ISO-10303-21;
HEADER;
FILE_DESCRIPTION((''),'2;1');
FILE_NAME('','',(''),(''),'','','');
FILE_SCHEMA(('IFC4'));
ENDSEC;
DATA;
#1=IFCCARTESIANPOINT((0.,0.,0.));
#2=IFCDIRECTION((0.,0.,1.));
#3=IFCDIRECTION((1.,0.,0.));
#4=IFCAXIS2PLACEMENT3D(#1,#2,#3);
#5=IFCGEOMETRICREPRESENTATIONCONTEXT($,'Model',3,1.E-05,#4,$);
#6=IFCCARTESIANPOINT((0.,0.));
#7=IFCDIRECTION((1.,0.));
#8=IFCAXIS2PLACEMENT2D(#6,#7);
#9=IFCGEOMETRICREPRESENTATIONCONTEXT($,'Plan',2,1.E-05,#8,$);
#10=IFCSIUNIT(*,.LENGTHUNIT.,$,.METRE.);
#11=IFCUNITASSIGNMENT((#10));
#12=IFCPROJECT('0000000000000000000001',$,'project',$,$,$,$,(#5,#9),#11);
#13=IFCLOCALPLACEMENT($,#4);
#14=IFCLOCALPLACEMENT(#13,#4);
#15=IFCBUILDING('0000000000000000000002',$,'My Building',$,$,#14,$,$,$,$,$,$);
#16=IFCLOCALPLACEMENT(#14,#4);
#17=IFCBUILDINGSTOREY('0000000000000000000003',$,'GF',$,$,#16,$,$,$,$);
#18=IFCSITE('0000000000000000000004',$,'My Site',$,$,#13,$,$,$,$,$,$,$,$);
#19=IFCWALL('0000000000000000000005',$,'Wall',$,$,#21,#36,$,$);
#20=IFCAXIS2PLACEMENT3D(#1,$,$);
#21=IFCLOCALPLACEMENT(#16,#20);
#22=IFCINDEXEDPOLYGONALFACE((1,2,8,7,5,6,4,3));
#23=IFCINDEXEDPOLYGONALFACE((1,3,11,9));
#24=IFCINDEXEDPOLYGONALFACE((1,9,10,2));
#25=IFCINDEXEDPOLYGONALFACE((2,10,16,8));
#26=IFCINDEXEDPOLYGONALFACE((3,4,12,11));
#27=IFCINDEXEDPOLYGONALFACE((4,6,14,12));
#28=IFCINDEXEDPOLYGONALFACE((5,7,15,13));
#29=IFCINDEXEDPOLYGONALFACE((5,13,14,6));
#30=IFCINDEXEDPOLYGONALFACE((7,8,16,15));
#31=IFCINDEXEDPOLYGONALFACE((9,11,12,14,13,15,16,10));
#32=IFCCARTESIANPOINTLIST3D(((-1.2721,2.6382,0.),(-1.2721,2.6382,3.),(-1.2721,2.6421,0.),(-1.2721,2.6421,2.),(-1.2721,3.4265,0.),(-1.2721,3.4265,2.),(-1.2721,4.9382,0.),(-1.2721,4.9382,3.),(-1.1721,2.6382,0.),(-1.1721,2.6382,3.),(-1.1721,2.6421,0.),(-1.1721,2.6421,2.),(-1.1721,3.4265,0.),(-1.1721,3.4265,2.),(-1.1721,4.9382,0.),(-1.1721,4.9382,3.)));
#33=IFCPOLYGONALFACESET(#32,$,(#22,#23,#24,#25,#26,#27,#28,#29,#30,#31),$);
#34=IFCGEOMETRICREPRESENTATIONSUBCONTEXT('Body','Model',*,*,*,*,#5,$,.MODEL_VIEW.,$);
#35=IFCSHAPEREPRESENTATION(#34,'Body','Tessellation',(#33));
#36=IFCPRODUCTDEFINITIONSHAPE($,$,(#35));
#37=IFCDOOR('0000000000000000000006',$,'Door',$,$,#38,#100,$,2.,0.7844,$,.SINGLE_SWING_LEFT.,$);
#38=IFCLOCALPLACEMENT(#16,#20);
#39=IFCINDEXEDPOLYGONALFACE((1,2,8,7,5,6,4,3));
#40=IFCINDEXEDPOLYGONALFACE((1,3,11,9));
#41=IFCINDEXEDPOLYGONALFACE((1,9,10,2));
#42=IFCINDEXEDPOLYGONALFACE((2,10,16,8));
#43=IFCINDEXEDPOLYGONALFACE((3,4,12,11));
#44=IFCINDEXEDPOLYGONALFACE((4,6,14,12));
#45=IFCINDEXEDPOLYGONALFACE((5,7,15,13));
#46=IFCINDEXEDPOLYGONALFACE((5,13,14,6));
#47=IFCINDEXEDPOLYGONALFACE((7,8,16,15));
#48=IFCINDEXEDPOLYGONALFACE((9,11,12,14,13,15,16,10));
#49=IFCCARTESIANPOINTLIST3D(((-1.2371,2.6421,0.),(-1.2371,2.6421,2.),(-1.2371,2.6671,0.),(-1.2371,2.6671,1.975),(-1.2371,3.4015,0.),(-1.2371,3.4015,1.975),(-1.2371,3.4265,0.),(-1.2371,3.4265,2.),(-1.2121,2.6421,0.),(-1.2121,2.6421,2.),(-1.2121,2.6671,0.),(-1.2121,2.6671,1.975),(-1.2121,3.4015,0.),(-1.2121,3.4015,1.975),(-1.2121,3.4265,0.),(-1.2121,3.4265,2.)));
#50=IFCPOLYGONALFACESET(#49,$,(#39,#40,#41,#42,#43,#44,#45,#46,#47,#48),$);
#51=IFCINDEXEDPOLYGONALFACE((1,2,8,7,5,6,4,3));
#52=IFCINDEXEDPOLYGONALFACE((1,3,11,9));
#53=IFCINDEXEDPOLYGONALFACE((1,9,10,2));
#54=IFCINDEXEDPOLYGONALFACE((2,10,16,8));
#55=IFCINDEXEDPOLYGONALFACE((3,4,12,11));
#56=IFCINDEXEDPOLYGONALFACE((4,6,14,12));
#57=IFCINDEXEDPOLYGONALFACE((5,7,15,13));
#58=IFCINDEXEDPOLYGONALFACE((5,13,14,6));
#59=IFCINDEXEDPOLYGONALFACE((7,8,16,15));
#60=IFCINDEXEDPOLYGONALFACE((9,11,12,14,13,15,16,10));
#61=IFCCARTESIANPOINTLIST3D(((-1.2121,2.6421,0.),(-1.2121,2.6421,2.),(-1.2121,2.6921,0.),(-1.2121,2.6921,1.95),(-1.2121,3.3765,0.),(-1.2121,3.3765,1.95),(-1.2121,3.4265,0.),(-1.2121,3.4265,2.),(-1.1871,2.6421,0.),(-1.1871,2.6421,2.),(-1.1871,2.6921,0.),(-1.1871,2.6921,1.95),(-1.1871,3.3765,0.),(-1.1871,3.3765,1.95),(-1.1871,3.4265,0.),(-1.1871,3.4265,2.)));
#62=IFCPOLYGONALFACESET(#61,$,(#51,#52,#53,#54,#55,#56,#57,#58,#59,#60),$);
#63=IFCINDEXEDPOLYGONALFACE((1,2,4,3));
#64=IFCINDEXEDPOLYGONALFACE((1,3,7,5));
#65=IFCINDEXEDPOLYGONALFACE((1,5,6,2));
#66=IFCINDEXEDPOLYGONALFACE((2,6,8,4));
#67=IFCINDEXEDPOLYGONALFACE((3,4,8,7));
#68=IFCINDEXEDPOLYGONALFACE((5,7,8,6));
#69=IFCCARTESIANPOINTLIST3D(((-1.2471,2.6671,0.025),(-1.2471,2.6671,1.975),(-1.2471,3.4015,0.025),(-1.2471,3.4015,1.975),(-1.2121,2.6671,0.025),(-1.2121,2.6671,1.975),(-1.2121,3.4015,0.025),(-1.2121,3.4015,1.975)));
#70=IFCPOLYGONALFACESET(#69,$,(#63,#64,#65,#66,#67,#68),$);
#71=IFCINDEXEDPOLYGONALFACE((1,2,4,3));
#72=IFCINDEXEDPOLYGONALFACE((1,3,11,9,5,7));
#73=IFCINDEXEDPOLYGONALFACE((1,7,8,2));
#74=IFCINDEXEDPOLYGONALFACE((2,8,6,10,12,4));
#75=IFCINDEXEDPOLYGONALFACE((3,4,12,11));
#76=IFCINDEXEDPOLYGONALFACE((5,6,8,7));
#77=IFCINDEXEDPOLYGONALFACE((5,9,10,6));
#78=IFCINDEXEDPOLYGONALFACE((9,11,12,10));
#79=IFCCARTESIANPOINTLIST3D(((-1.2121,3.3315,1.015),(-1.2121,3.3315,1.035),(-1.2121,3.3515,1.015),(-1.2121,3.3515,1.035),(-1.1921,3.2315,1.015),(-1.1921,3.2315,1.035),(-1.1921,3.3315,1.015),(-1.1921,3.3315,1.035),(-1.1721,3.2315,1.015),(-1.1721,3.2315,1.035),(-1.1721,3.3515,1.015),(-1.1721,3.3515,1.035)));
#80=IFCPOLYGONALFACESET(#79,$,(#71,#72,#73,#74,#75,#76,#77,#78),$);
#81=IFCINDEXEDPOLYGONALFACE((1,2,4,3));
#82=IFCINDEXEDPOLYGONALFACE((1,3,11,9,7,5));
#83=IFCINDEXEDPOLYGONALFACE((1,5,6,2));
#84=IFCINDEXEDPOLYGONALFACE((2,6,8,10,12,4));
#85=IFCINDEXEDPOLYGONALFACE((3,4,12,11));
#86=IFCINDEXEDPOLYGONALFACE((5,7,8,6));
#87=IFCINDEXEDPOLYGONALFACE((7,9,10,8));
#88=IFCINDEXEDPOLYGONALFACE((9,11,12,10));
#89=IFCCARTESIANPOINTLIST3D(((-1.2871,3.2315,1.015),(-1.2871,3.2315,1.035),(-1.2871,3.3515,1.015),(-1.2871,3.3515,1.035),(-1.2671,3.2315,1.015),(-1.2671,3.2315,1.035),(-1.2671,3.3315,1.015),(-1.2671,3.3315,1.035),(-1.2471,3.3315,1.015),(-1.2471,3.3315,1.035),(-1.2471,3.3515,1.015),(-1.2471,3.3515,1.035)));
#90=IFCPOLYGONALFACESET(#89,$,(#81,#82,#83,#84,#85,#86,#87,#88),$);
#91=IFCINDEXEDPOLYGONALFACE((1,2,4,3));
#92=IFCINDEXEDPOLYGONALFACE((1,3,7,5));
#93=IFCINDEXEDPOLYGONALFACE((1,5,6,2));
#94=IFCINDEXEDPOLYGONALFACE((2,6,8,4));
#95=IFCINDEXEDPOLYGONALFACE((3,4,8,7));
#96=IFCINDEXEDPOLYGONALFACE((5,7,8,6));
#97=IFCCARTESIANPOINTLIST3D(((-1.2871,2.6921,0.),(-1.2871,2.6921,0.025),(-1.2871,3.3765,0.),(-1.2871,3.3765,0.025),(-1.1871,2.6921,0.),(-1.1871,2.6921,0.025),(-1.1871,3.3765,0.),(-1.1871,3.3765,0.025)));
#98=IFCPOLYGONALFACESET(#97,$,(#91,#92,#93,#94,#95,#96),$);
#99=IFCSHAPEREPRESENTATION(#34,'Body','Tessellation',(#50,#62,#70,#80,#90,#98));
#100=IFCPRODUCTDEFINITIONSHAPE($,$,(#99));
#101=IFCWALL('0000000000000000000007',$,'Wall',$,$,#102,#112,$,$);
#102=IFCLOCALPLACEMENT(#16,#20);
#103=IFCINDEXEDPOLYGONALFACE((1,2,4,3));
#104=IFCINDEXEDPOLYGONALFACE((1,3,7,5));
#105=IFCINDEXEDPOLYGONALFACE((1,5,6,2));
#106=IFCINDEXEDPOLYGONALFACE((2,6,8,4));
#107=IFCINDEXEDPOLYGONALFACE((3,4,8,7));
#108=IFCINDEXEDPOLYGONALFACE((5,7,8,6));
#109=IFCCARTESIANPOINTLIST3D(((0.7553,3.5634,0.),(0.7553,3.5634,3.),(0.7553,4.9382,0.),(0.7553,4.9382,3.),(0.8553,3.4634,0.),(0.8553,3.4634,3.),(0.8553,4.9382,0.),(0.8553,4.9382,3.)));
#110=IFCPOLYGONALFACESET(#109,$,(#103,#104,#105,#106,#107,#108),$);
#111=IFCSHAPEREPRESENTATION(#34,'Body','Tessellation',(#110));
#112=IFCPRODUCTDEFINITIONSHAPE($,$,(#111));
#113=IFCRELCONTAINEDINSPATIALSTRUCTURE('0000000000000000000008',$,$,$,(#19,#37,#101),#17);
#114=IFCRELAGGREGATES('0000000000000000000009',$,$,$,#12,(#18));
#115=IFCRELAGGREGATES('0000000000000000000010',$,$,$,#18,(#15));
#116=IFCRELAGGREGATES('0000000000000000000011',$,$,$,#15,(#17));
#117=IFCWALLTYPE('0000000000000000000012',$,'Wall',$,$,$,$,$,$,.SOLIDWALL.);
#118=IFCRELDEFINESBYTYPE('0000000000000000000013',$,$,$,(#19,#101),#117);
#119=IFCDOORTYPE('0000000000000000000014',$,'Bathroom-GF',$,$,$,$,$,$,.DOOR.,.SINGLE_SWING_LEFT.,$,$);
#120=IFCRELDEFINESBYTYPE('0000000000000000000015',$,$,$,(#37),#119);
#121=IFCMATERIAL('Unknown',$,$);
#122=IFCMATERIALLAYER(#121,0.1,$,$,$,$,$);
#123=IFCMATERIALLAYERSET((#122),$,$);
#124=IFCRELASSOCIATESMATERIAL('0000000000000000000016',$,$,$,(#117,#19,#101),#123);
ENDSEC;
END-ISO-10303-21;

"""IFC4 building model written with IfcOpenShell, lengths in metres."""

from ifc_helpers import new_model, entity, si_unit, frame, origin_with_axes, origin_2d_with_axis, place, context, subcontext, project, spatial, line, indexed_curve, outline, extrude, shape, source, transform, mapped, material, layer, layer_set, layer_usage, type_object, type_shapes, element, fill, save


model = new_model("IFC4")

# Units and contexts
model_context = context("Model", 3, precision=1e-05, world=origin_with_axes())
plan_context = context("Plan", 2, precision=1e-05, world=origin_2d_with_axis())
body_context_1 = subcontext(model_context, "Body", "Model", "MODEL_VIEW")
body_context_2 = subcontext(plan_context, "Body", "Plan", "PLAN_VIEW")
ifc_project = project(units=[si_unit("LENGTHUNIT", "METRE")], contexts=[model_context, plan_context])

# Site, building, storey
site_placement = place(None, origin_with_axes())
site = spatial("IfcSite", under=ifc_project, at=site_placement, Name="My Site")
building_placement = place(site_placement, origin_with_axes())
building = spatial("IfcBuilding", under=site, at=building_placement, Name="My Building")
storey_placement = place(building_placement, origin_with_axes())
storey = spatial("IfcBuildingStorey", under=building, at=storey_placement, Name="GF")

# Shared definitions
ifc_material = material(Name="Unknown")

# Shared definitions
ifc_layer_1 = layer(ifc_material, 0.1)
ifc_layer_set_1 = layer_set([ifc_layer_1])
wall_type = type_object("IfcWallType", Name="Wall", PredefinedType="SOLIDWALL", material=ifc_layer_set_1)

# Wall, opening, door
ifc_layer_usage_1 = layer_usage(ifc_layer_set_1, "AXIS2", "POSITIVE", 0.0)
wall_1_placement = place(storey_placement, frame((-1.1721, 2.6382, 0.0), z_axis=(0.0, 0.0, 1.0), x_axis=(0.0, 1.0, 0.0)))
wall_1 = element("IfcWall", 1, at=wall_1_placement, inside=storey, type_object=wall_type, material=ifc_layer_usage_1, Name="Wall", context=body_context_1, shape_type="SweptSolid", body=[
    extrude(outline(indexed_curve([(0.0, 0.0), (0.0, 0.1), (2.3, 0.1), (2.3, 0.0)], segments=[line(1, 2, 3, 4, 1)])), origin_with_axes(), (0.0, 0.0, 1.0), 3.0),
])
shared_shape_1 = source(origin_with_axes(), body_context_1, "Body", "SweptSolid", [
    extrude(outline(indexed_curve([(0.0, 0.0), (0.7844, 0.0), (0.7844, 2.0), (0.0, 2.0)], segments=[line(1, 2, 3, 4, 1)])), frame((0.0, -0.6, 0.0), z_axis=(0.0, -1.0, 0.0), x_axis=(1.0, 0.0, 0.0)), (0.0, 0.0, -1.0), 1.2),
])
opening_1_placement = place(wall_1_placement, frame((0.0039, 0.015, 0.0), z_axis=(0.0, 0.0, 1.0), x_axis=(1.0, 0.0, 0.0)))
opening_1 = element("IfcOpeningElement", 2, at=opening_1_placement, cuts=wall_1, PredefinedType="OPENING", context=body_context_1, shape_type="MappedRepresentation", body=[
    mapped(shared_shape_1, transform((0.0, 0.0, 0.0), x_axis=(1.0, 0.0, 0.0), y_axis=(0.0, 1.0, 0.0), z_axis=(0.0, 0.0, 1.0), scale=1.0)),
])
door_type_1 = type_object("IfcDoorType", Name="Bathroom-GF", OperationType="SINGLE_SWING_LEFT", PredefinedType="DOOR")
shared_shape_2 = source(origin_with_axes(), body_context_1, "Body", "SweptSolid", [
    extrude(outline(indexed_curve([(0.0, 0.0), (0.0, 2.0), (0.7844, 2.0), (0.7844, 0.0), (0.7594, 0.0), (0.7594, 1.975), (0.025, 1.975), (0.025, 0.0)], segments=[line(1, 2, 3, 4, 5, 6, 7, 8, 1)])), frame((0.0, 0.025, 0.0), z_axis=(0.0, -1.0, 0.0), x_axis=(1.0, 0.0, 0.0)), (0.0, 0.0, -1.0), 0.025),
    extrude(outline(indexed_curve([(0.0, 0.0), (0.0, 2.0), (0.7844, 2.0), (0.7844, 0.0), (0.7344, 0.0), (0.7344, 1.95), (0.05, 1.95), (0.05, 0.0)], segments=[line(1, 2, 3, 4, 5, 6, 7, 8, 1)])), frame((0.0, 0.0, 0.0), z_axis=(0.0, -1.0, 0.0), x_axis=(1.0, 0.0, 0.0)), (0.0, 0.0, -1.0), 0.025),
    extrude(outline(indexed_curve([(0.0, 0.0), (0.7344, 0.0), (0.7344, 0.035), (0.0, 0.035)], segments=[line(1, 2, 3, 4, 1)])), frame((0.025, 0.025, 0.025), z_axis=(0.0, 0.0, 1.0), x_axis=(1.0, 0.0, 0.0)), (0.0, 0.0, 1.0), 1.95),
    extrude(outline(indexed_curve([(0.0, 0.0), (0.0, -0.04), (-0.12, -0.04), (-0.12, -0.02), (-0.02, -0.02), (-0.02, 0.0)], segments=[line(1, 2, 3, 4, 5, 6, 1)])), frame((0.7094, 0.025, 1.015), z_axis=(0.0, 0.0, 1.0), x_axis=(1.0, 0.0, 0.0)), (0.0, 0.0, 1.0), 0.02),
    extrude(outline(indexed_curve([(0.0, 0.0), (0.0, 0.04), (-0.12, 0.04), (-0.12, 0.02), (-0.02, 0.02), (-0.02, 0.0)], segments=[line(1, 2, 3, 4, 5, 6, 1)])), frame((0.7094, 0.06, 1.015), z_axis=(0.0, 0.0, 1.0), x_axis=(1.0, 0.0, 0.0)), (0.0, 0.0, 1.0), 0.02),
    extrude(outline(indexed_curve([(0.0, 0.0), (0.6844, 0.0), (0.6844, 0.1), (0.0, 0.1)], segments=[line(1, 2, 3, 4, 1)])), frame((0.05, 0.0, 0.0), z_axis=(0.0, 0.0, 1.0), x_axis=(1.0, 0.0, 0.0)), (0.0, 0.0, 1.0), 0.025),
])
shared_shape_3 = source(origin_with_axes(), body_context_2, "Body", "Curve2D", [
    entity("IfcIndexedPolyCurve", entity("IfcCartesianPointList2D", [[0.0, 0.0], [0.0, 0.05], [0.025, 0.05], [0.025, 0.025], [0.05, 0.025], [0.05, 0.0]]), [entity("IfcLineIndex", [1, 2, 3, 4, 5, 6, 1])]),
    entity("IfcIndexedPolyCurve", entity("IfcCartesianPointList2D", [[0.7844, 0.0], [0.7844, 0.05], [0.7594, 0.05], [0.7594, 0.025], [0.7344, 0.025], [0.7344, 0.0]]), [entity("IfcLineIndex", [1, 2, 3, 4, 5, 6, 1])]),
    entity("IfcTrimmedCurve", entity("IfcEllipse", entity("IfcAxis2Placement2D", entity("IfcCartesianPoint", [0.06, 0.05]), entity("IfcDirection", [1.0, 0.0])), 0.6994, 0.7344), [entity("IfcCartesianPoint", [0.7594, 0.05])], [entity("IfcCartesianPoint", [0.06, 0.7844])], True, "CARTESIAN"),
    entity("IfcIndexedPolyCurve", entity("IfcCartesianPointList2D", [[0.025, 0.05], [0.06, 0.05], [0.06, 0.7844], [0.025, 0.7844]]), [entity("IfcLineIndex", [1, 2, 3, 4, 1])]),
])
type_shapes(door_type_1, [shared_shape_2, shared_shape_3])
door_1_placement = place(opening_1_placement, frame((0.0, 0.0, 0.0), z_axis=(0.0, 0.0, 1.0), x_axis=(1.0, 0.0, 0.0)))
door_1 = element("IfcDoor", 3, at=door_1_placement, inside=storey, type_object=door_type_1, Name="Door", OperationType="SINGLE_SWING_LEFT", OverallHeight=2.0, OverallWidth=0.7844, shapes=[
    shape(body_context_1, "Body", "MappedRepresentation", [mapped(shared_shape_2, transform((0.0, 0.0, 0.0), x_axis=(1.0, 0.0, 0.0), y_axis=(0.0, 1.0, 0.0), z_axis=(0.0, 0.0, 1.0), scale=1.0))]),
    shape(body_context_2, "Body", "MappedRepresentation", [mapped(shared_shape_3, transform((0.0, 0.0, 0.0), x_axis=(1.0, 0.0, 0.0), y_axis=(0.0, 1.0, 0.0), z_axis=(0.0, 0.0, 1.0), scale=1.0))]),
])
fill(opening_1, door_1)

# Wall
ifc_layer_usage_2 = layer_usage(ifc_layer_set_1, "AXIS2", "POSITIVE", 0.0)
wall_2_placement = place(storey_placement, frame((0.7553, 5.0382, 0.0), z_axis=(0.0, 0.0, 1.0), x_axis=(0.0, -1.0, 0.0)))
element("IfcWall", 4, at=wall_2_placement, inside=storey, type_object=wall_type, material=ifc_layer_usage_2, Name="Wall", context=body_context_1, shape_type="SweptSolid", body=[
    extrude(outline(indexed_curve([(0.1, 0.0), (0.1, 0.1), (1.5748, 0.1), (1.4748, 0.0)], segments=[line(1, 2, 3, 4, 1)])), origin_with_axes(), (0.0, 0.0, 1.0), 3.0),
])

save(model, "model.ifc")
